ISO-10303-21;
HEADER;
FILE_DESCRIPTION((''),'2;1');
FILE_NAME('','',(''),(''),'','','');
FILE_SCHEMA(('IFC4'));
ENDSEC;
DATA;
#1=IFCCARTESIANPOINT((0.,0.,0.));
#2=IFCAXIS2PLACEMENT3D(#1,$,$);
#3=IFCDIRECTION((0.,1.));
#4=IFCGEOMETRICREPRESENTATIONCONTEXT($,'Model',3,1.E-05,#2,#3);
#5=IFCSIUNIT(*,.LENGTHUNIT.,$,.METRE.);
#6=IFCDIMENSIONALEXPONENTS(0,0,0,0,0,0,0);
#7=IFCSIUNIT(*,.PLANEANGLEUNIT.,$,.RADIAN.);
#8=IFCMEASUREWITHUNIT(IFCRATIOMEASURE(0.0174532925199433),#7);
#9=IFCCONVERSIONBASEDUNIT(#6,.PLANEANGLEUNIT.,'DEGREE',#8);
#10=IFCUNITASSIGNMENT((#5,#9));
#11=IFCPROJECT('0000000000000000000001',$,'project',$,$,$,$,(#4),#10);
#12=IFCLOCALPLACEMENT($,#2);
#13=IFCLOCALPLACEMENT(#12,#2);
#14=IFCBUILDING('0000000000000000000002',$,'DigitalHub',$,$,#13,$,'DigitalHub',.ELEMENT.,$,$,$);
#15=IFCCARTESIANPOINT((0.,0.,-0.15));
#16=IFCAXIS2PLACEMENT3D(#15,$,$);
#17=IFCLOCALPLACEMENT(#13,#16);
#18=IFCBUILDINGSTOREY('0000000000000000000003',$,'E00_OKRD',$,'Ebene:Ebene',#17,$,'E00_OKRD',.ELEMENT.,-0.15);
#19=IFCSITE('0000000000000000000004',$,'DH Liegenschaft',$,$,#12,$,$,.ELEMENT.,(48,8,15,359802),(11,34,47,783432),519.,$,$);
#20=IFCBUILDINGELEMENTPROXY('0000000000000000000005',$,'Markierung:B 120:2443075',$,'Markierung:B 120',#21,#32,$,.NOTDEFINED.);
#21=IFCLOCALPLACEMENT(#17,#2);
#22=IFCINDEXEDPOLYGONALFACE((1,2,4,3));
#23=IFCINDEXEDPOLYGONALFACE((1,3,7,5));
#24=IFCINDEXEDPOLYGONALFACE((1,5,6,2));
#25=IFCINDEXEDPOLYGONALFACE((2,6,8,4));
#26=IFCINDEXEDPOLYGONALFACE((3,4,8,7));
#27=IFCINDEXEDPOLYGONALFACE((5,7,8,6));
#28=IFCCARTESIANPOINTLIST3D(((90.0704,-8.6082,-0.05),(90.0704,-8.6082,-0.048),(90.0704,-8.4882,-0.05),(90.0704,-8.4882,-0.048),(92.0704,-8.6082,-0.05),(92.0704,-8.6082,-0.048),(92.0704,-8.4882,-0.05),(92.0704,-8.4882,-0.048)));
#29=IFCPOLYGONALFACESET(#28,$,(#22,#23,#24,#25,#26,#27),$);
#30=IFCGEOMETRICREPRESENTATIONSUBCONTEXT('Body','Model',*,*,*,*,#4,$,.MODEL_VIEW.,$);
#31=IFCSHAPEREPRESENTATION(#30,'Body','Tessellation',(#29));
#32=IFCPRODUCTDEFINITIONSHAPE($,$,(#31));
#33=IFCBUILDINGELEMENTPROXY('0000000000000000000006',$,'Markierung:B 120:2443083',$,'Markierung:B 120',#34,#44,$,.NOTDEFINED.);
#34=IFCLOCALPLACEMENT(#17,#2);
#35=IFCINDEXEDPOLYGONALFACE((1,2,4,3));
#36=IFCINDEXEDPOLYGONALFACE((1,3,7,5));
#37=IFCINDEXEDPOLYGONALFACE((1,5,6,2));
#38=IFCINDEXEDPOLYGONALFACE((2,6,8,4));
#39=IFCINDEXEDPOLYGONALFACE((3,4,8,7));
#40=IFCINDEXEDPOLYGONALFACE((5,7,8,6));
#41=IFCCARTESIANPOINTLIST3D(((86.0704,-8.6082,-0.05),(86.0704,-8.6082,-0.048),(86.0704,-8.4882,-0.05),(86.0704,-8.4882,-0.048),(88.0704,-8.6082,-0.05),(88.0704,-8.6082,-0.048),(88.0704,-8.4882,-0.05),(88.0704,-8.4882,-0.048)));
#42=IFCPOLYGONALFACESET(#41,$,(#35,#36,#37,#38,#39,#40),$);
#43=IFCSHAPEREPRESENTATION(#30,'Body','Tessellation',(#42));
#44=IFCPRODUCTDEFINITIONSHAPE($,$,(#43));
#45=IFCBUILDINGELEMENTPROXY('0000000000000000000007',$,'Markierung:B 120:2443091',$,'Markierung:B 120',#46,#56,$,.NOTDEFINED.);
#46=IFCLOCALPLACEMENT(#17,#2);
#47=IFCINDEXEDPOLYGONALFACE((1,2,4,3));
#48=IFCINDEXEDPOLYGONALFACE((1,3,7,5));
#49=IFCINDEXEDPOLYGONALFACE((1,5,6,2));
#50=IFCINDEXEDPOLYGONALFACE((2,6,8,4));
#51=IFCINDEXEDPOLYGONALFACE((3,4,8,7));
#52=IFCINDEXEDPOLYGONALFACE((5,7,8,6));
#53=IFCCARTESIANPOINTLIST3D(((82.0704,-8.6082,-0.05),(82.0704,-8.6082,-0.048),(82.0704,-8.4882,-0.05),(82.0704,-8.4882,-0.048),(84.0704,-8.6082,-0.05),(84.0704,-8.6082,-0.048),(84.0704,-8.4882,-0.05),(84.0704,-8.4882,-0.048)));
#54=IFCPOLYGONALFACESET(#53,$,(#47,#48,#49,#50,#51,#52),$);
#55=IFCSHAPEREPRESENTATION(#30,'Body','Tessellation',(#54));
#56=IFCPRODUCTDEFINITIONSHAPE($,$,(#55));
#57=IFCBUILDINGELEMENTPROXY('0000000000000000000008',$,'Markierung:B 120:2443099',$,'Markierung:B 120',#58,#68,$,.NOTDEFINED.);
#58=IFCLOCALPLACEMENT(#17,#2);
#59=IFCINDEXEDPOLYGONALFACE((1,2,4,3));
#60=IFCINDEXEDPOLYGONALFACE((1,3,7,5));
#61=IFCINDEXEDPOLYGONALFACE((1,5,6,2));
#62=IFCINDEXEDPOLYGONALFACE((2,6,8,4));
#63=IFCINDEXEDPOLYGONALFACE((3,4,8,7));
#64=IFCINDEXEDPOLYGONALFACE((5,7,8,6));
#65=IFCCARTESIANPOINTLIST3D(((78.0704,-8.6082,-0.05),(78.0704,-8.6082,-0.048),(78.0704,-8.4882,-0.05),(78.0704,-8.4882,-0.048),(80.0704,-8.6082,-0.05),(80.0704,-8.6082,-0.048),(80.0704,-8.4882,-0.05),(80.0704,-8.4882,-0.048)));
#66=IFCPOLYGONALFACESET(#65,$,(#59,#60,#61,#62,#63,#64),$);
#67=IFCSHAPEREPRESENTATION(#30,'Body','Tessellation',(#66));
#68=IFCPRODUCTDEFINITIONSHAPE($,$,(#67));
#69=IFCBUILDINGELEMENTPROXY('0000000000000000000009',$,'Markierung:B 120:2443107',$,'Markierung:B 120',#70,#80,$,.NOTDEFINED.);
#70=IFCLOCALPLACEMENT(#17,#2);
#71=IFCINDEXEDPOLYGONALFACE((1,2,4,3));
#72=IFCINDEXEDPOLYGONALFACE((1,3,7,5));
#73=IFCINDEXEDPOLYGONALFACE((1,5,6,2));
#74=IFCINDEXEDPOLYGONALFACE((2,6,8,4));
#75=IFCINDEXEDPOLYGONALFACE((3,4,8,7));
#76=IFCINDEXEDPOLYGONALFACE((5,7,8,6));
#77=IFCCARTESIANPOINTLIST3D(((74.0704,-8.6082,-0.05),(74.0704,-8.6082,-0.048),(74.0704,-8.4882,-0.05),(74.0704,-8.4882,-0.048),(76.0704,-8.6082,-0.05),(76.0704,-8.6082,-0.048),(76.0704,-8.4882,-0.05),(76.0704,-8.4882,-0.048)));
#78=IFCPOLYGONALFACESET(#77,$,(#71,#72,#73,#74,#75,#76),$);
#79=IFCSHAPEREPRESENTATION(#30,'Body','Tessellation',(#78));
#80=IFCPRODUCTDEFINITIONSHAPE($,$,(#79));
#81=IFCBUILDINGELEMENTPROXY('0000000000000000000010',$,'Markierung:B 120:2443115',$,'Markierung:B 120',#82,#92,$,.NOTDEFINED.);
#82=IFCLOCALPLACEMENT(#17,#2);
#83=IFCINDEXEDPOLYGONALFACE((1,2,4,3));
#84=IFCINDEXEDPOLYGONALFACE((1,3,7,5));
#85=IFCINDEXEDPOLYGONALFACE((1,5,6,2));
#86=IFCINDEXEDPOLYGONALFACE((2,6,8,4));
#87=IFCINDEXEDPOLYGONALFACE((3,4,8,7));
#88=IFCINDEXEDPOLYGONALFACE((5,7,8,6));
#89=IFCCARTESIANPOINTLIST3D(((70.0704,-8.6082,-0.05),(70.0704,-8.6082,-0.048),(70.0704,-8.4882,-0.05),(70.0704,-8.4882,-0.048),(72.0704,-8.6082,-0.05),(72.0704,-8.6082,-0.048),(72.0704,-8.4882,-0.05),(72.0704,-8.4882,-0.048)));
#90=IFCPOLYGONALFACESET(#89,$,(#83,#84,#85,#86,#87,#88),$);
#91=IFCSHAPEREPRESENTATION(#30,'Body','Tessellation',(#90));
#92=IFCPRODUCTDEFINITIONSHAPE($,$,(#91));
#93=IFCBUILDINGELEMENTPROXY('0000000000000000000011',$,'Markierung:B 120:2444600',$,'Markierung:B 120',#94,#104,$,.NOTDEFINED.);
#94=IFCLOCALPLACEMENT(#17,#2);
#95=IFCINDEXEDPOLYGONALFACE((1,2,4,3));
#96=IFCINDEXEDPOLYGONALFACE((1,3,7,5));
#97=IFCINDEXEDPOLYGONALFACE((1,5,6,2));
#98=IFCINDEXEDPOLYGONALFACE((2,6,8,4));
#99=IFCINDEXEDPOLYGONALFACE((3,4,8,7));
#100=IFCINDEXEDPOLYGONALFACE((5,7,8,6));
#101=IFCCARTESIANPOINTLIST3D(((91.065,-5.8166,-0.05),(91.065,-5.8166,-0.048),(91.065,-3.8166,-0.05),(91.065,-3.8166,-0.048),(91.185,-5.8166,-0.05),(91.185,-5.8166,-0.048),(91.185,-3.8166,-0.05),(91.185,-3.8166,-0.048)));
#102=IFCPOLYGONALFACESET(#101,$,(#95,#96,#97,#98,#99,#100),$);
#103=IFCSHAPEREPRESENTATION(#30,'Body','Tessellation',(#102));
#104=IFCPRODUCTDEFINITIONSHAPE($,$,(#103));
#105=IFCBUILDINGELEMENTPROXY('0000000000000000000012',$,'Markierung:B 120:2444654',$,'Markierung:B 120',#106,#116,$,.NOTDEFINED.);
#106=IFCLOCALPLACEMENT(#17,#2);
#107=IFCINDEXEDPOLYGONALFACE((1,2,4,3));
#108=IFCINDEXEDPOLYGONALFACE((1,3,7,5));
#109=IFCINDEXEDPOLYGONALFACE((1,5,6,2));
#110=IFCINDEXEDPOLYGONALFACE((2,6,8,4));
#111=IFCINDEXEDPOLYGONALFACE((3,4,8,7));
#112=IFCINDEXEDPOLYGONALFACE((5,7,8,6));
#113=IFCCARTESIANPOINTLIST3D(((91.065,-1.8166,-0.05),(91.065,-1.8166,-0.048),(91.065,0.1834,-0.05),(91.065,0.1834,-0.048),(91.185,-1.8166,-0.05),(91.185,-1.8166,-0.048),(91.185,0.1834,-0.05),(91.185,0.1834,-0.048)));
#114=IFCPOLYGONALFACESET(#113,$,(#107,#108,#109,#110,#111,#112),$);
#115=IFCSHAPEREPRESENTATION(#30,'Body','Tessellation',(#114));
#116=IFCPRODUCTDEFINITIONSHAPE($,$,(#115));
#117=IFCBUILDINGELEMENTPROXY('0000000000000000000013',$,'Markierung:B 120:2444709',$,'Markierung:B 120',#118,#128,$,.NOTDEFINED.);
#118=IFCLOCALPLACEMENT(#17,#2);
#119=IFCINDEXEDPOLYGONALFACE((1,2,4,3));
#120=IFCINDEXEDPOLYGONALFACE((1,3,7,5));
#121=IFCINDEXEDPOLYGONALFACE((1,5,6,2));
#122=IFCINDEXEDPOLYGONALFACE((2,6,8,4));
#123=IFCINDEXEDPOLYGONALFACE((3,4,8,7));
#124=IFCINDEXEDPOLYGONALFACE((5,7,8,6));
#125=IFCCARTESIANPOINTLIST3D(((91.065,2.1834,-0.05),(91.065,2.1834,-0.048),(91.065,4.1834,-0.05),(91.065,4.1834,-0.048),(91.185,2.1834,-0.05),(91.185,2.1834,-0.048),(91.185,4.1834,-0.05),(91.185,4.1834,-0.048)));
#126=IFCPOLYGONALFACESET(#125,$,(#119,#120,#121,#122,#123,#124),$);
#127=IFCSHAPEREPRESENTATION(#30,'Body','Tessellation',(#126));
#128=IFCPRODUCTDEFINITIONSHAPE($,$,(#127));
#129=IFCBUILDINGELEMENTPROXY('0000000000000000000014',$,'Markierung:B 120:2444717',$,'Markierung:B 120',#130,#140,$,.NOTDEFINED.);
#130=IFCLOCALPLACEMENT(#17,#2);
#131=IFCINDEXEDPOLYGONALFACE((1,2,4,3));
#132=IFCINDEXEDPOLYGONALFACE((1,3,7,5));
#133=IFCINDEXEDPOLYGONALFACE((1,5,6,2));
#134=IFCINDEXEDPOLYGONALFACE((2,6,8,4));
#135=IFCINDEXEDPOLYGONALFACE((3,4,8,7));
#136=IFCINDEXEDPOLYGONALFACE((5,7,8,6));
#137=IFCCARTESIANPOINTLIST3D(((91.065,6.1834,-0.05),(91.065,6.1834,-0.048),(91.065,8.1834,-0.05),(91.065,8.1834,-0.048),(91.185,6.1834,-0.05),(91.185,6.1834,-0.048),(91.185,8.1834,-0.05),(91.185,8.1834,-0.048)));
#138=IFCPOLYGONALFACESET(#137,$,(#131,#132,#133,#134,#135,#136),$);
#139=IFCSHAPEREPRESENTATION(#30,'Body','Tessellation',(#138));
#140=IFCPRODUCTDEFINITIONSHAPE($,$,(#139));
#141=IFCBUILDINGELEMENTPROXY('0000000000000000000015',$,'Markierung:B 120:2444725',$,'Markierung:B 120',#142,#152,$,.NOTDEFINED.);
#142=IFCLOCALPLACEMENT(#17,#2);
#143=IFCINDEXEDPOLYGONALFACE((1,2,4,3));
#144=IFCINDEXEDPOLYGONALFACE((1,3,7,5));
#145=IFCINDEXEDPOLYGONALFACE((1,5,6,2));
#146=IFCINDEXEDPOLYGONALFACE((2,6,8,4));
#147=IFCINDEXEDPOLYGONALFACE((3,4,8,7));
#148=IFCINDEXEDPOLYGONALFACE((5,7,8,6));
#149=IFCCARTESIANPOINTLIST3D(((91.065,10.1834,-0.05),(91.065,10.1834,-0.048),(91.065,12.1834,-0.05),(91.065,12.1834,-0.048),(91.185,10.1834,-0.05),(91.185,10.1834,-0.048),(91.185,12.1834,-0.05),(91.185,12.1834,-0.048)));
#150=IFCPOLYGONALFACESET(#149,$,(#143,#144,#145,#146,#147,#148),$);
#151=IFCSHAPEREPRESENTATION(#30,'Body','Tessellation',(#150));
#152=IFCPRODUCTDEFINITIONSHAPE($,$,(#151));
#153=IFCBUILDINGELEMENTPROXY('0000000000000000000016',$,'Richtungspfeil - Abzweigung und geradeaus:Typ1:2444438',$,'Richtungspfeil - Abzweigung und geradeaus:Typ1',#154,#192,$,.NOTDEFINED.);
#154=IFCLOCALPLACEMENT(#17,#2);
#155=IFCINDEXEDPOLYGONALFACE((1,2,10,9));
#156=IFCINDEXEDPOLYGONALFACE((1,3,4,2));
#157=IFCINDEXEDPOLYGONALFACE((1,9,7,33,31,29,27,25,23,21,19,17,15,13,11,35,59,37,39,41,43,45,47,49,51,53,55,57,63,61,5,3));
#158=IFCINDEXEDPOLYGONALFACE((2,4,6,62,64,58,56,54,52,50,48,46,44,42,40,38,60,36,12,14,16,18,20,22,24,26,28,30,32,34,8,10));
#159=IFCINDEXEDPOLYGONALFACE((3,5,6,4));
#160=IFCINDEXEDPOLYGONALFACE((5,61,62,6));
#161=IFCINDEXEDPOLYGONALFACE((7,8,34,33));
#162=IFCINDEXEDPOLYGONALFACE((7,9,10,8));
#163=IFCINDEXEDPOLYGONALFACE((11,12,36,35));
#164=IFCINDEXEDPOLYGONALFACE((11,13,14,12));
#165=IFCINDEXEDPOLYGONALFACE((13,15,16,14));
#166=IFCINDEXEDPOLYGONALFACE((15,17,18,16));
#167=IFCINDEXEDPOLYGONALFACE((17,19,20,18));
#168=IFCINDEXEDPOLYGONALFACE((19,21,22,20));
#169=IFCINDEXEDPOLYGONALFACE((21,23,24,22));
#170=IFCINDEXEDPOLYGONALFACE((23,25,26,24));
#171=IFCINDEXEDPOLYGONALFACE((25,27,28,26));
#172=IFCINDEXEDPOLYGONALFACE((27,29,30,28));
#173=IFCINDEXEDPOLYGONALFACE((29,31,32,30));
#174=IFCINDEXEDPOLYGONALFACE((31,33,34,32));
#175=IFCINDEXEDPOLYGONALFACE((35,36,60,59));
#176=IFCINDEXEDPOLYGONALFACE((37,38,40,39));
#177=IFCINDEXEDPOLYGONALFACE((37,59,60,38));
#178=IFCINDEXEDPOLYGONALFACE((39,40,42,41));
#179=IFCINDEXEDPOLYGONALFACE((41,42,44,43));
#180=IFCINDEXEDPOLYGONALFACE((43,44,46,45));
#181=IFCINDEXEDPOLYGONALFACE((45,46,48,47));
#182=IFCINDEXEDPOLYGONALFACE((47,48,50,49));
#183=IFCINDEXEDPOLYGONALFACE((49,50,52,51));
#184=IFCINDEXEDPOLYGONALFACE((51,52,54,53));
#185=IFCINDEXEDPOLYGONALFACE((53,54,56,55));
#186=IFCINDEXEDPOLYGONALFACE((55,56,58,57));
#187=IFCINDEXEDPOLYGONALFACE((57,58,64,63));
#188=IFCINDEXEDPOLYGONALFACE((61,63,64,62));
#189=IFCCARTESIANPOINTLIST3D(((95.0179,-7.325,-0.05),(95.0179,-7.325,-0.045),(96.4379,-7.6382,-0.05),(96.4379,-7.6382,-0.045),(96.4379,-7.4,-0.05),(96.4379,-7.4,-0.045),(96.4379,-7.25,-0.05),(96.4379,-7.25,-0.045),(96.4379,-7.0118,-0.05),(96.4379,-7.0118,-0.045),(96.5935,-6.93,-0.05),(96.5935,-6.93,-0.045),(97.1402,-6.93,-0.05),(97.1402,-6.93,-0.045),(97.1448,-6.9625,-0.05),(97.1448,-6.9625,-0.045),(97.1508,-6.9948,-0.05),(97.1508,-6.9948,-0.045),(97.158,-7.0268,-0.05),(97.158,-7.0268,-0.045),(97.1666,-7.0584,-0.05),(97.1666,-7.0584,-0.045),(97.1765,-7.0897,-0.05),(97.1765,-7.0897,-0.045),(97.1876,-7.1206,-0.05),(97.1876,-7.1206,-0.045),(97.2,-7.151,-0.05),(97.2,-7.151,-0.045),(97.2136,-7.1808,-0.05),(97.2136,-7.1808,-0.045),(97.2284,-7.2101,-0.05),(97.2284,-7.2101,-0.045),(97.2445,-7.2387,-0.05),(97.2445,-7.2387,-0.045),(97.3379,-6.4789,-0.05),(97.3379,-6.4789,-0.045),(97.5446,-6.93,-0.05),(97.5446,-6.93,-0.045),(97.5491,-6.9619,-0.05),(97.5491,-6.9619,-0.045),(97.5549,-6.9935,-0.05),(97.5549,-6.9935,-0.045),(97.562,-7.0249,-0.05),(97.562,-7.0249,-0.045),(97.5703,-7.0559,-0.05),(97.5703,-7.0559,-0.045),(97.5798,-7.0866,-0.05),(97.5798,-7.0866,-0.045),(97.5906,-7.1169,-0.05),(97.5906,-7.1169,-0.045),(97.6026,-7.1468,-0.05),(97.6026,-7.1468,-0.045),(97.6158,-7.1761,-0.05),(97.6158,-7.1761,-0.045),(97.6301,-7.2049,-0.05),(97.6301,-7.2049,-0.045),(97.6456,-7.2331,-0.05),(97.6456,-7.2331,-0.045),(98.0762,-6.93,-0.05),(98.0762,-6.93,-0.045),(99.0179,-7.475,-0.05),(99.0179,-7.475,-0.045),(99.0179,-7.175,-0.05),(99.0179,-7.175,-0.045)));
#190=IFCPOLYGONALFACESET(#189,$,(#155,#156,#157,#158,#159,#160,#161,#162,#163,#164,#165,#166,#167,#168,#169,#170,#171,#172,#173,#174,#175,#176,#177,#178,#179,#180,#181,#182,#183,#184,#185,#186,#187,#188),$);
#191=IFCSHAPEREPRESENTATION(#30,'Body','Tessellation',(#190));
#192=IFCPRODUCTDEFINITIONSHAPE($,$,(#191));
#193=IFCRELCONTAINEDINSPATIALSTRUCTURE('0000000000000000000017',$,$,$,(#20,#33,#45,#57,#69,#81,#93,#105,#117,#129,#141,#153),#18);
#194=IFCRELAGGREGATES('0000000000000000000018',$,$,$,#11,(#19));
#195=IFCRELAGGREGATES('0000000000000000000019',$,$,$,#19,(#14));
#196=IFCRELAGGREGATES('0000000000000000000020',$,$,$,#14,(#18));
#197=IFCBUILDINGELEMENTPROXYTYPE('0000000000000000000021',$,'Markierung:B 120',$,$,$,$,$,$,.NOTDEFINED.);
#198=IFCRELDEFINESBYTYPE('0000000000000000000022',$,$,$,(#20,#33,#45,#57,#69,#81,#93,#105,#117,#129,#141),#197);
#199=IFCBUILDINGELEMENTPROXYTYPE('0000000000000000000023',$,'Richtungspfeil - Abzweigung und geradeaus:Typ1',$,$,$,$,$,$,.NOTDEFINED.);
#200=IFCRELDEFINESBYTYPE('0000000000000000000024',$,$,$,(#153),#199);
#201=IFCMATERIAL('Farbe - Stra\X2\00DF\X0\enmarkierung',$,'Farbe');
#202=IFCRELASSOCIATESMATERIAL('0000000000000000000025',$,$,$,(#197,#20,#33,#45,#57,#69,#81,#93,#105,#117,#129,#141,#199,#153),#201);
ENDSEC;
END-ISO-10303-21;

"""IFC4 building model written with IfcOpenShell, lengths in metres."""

from ifc_helpers import new_model, entity, si_unit, converted_unit, direction, frame, origin, place, context, subcontext, project, spatial, indexed_curve, outline, extrude, source, transform, mapped, material, type_object, type_shapes, element, save


model = new_model("IFC4")

# Units and contexts
model_context = context("Model", 3, precision=1e-05, world=origin(), true_north=direction((0.0, 1.0)))
body_context = subcontext(model_context, "Body", "Model", "MODEL_VIEW")
ifc_project = project(units=[si_unit("LENGTHUNIT", "METRE"), converted_unit("PLANEANGLEUNIT", "DEGREE", entity("IfcRatioMeasure", 0.0174532925199433), si_unit("PLANEANGLEUNIT", "RADIAN"), dimensions=[0, 0, 0, 0, 0, 0, 0])], contexts=[model_context])

# Site, building, storey
site_placement = place(None, frame((0.0, 0.0, 0.0)))
site = spatial("IfcSite", under=ifc_project, at=site_placement, Name="DH Liegenschaft", CompositionType="ELEMENT", RefLatitude=(48, 8, 15, 359802), RefLongitude=(11, 34, 47, 783432), RefElevation=519.0)
building_placement = place(site_placement, origin())
building = spatial("IfcBuilding", under=site, at=building_placement, Name="DigitalHub", LongName="DigitalHub", CompositionType="ELEMENT")
storey_placement = place(building_placement, frame((0.0, 0.0, -0.15)))
storey = spatial("IfcBuildingStorey", under=building, at=storey_placement, Name="E00_OKRD", ObjectType="Ebene:Ebene", LongName="E00_OKRD", CompositionType="ELEMENT", Elevation=-0.15)

# Building element proxies
ifc_material_1 = material(Name="Farbe - Straßenmarkierung", Category="Farbe")
building_element_proxy_type_1 = type_object("IfcBuildingElementProxyType", Name="Markierung:B 120", PredefinedType="NOTDEFINED", material=ifc_material_1)
shared_shape_1 = source(origin(), body_context, "Body", "SweptSolid", [
    extrude(outline(indexed_curve([(-0.06, -1.0), (0.06, -1.0), (0.06, 1.0), (-0.06, 1.0), (-0.06, -1.0)], self_intersect=False)), frame((0.06, 1.0, 0.0), z_axis=(0.0, 0.0, 1.0), x_axis=(-1.0, 0.0, 0.0)), (0.0, 0.0, 1.0), 0.002),
])
type_shapes(building_element_proxy_type_1, [shared_shape_1])
for number, where, z_axis, x_axis, name in (
    (1, (92.0704, -8.6082, -0.05), (0.0, 0.0, 1.0), (0.0, 1.0, 0.0), "Markierung:B 120:2443075"),
    (2, (88.0704, -8.6082, -0.05), (0.0, 0.0, 1.0), (0.0, 1.0, 0.0), "Markierung:B 120:2443083"),
    (3, (84.0704, -8.6082, -0.05), (0.0, 0.0, 1.0), (0.0, 1.0, 0.0), "Markierung:B 120:2443091"),
    (4, (80.0704, -8.6082, -0.05), (0.0, 0.0, 1.0), (0.0, 1.0, 0.0), "Markierung:B 120:2443099"),
    (5, (76.0704, -8.6082, -0.05), (0.0, 0.0, 1.0), (0.0, 1.0, 0.0), "Markierung:B 120:2443107"),
    (6, (72.0704, -8.6082, -0.05), (0.0, 0.0, 1.0), (0.0, 1.0, 0.0), "Markierung:B 120:2443115"),
):
    element("IfcBuildingElementProxy", number, at=place(storey_placement, frame(where, z_axis=z_axis, x_axis=x_axis)), inside=storey, type_object=building_element_proxy_type_1, material=ifc_material_1, Name=name, ObjectType="Markierung:B 120", PredefinedType="NOTDEFINED", context=body_context, shape_type="MappedRepresentation", body=[
        mapped(shared_shape_1, transform((0.0, 0.0, 0.0), scale=1.0)),
    ])
for number, where, name in (
    (7, (91.065, -5.8166, -0.05), "Markierung:B 120:2444600"),
    (8, (91.065, -1.8166, -0.05), "Markierung:B 120:2444654"),
    (9, (91.065, 2.1834, -0.05), "Markierung:B 120:2444709"),
    (10, (91.065, 6.1834, -0.05), "Markierung:B 120:2444717"),
    (11, (91.065, 10.1834, -0.05), "Markierung:B 120:2444725"),
):
    element("IfcBuildingElementProxy", number, at=place(storey_placement, frame(where)), inside=storey, type_object=building_element_proxy_type_1, material=ifc_material_1, Name=name, ObjectType="Markierung:B 120", PredefinedType="NOTDEFINED", context=body_context, shape_type="MappedRepresentation", body=[
        mapped(shared_shape_1, transform((0.0, 0.0, 0.0), scale=1.0)),
    ])
building_element_proxy_type_2 = type_object("IfcBuildingElementProxyType", Name="Richtungspfeil - Abzweigung und geradeaus:Typ1", PredefinedType="NOTDEFINED", material=ifc_material_1)
shared_shape_2 = source(origin(), body_context, "Body", "SweptSolid", [
    extrude(outline(indexed_curve([(-0.7248, -0.2822), (1.8563, -0.2822), (1.8476, 0.0177), (0.4776, -0.0802), (0.4613, -0.0525), (0.4461, -0.0242), (0.4321, 0.0048), (0.4193, 0.0343), (0.4076, 0.0642), (0.3972, 0.0946), (0.388, 0.1254), (0.38, 0.1566), (0.3733, 0.1881), (0.3679, 0.2198), (0.8992, 0.2352), (0.1481, 0.6647), (-0.5828, 0.1921), (-0.0364, 0.208), (-0.0308, 0.1757), (-0.0239, 0.1436), (-0.0158, 0.1118), (-0.0063, 0.0804), (0.0045, 0.0494), (0.0165, 0.0189), (0.0298, -0.0111), (0.0443, -0.0406), (0.06, -0.0694), (0.0768, -0.0975), (-0.7291, -0.1323), (-0.7361, 0.1058), (-2.1464, -0.2485), (-0.7179, -0.5203), (-0.7248, -0.2822)], self_intersect=False)), frame((0.261, 1.8473, 0.0), z_axis=(0.0, 0.0, 1.0), x_axis=(-0.029057, -0.999578, 0.0)), (0.0, 0.0, 1.0), 0.005),
])
type_shapes(building_element_proxy_type_2, [shared_shape_2])
proxy_1_placement = place(storey_placement, frame((99.0179, -7.4, -0.05), z_axis=(0.0, 0.0, 1.0), x_axis=(0.0, 1.0, 0.0)))
element("IfcBuildingElementProxy", 12, at=proxy_1_placement, inside=storey, type_object=building_element_proxy_type_2, material=ifc_material_1, Name="Richtungspfeil - Abzweigung und geradeaus:Typ1:2444438", ObjectType="Richtungspfeil - Abzweigung und geradeaus:Typ1", PredefinedType="NOTDEFINED", context=body_context, shape_type="MappedRepresentation", body=[
    mapped(shared_shape_2, transform((0.0, 0.0, 0.0), scale=1.0)),
])

save(model, "model.ifc")
